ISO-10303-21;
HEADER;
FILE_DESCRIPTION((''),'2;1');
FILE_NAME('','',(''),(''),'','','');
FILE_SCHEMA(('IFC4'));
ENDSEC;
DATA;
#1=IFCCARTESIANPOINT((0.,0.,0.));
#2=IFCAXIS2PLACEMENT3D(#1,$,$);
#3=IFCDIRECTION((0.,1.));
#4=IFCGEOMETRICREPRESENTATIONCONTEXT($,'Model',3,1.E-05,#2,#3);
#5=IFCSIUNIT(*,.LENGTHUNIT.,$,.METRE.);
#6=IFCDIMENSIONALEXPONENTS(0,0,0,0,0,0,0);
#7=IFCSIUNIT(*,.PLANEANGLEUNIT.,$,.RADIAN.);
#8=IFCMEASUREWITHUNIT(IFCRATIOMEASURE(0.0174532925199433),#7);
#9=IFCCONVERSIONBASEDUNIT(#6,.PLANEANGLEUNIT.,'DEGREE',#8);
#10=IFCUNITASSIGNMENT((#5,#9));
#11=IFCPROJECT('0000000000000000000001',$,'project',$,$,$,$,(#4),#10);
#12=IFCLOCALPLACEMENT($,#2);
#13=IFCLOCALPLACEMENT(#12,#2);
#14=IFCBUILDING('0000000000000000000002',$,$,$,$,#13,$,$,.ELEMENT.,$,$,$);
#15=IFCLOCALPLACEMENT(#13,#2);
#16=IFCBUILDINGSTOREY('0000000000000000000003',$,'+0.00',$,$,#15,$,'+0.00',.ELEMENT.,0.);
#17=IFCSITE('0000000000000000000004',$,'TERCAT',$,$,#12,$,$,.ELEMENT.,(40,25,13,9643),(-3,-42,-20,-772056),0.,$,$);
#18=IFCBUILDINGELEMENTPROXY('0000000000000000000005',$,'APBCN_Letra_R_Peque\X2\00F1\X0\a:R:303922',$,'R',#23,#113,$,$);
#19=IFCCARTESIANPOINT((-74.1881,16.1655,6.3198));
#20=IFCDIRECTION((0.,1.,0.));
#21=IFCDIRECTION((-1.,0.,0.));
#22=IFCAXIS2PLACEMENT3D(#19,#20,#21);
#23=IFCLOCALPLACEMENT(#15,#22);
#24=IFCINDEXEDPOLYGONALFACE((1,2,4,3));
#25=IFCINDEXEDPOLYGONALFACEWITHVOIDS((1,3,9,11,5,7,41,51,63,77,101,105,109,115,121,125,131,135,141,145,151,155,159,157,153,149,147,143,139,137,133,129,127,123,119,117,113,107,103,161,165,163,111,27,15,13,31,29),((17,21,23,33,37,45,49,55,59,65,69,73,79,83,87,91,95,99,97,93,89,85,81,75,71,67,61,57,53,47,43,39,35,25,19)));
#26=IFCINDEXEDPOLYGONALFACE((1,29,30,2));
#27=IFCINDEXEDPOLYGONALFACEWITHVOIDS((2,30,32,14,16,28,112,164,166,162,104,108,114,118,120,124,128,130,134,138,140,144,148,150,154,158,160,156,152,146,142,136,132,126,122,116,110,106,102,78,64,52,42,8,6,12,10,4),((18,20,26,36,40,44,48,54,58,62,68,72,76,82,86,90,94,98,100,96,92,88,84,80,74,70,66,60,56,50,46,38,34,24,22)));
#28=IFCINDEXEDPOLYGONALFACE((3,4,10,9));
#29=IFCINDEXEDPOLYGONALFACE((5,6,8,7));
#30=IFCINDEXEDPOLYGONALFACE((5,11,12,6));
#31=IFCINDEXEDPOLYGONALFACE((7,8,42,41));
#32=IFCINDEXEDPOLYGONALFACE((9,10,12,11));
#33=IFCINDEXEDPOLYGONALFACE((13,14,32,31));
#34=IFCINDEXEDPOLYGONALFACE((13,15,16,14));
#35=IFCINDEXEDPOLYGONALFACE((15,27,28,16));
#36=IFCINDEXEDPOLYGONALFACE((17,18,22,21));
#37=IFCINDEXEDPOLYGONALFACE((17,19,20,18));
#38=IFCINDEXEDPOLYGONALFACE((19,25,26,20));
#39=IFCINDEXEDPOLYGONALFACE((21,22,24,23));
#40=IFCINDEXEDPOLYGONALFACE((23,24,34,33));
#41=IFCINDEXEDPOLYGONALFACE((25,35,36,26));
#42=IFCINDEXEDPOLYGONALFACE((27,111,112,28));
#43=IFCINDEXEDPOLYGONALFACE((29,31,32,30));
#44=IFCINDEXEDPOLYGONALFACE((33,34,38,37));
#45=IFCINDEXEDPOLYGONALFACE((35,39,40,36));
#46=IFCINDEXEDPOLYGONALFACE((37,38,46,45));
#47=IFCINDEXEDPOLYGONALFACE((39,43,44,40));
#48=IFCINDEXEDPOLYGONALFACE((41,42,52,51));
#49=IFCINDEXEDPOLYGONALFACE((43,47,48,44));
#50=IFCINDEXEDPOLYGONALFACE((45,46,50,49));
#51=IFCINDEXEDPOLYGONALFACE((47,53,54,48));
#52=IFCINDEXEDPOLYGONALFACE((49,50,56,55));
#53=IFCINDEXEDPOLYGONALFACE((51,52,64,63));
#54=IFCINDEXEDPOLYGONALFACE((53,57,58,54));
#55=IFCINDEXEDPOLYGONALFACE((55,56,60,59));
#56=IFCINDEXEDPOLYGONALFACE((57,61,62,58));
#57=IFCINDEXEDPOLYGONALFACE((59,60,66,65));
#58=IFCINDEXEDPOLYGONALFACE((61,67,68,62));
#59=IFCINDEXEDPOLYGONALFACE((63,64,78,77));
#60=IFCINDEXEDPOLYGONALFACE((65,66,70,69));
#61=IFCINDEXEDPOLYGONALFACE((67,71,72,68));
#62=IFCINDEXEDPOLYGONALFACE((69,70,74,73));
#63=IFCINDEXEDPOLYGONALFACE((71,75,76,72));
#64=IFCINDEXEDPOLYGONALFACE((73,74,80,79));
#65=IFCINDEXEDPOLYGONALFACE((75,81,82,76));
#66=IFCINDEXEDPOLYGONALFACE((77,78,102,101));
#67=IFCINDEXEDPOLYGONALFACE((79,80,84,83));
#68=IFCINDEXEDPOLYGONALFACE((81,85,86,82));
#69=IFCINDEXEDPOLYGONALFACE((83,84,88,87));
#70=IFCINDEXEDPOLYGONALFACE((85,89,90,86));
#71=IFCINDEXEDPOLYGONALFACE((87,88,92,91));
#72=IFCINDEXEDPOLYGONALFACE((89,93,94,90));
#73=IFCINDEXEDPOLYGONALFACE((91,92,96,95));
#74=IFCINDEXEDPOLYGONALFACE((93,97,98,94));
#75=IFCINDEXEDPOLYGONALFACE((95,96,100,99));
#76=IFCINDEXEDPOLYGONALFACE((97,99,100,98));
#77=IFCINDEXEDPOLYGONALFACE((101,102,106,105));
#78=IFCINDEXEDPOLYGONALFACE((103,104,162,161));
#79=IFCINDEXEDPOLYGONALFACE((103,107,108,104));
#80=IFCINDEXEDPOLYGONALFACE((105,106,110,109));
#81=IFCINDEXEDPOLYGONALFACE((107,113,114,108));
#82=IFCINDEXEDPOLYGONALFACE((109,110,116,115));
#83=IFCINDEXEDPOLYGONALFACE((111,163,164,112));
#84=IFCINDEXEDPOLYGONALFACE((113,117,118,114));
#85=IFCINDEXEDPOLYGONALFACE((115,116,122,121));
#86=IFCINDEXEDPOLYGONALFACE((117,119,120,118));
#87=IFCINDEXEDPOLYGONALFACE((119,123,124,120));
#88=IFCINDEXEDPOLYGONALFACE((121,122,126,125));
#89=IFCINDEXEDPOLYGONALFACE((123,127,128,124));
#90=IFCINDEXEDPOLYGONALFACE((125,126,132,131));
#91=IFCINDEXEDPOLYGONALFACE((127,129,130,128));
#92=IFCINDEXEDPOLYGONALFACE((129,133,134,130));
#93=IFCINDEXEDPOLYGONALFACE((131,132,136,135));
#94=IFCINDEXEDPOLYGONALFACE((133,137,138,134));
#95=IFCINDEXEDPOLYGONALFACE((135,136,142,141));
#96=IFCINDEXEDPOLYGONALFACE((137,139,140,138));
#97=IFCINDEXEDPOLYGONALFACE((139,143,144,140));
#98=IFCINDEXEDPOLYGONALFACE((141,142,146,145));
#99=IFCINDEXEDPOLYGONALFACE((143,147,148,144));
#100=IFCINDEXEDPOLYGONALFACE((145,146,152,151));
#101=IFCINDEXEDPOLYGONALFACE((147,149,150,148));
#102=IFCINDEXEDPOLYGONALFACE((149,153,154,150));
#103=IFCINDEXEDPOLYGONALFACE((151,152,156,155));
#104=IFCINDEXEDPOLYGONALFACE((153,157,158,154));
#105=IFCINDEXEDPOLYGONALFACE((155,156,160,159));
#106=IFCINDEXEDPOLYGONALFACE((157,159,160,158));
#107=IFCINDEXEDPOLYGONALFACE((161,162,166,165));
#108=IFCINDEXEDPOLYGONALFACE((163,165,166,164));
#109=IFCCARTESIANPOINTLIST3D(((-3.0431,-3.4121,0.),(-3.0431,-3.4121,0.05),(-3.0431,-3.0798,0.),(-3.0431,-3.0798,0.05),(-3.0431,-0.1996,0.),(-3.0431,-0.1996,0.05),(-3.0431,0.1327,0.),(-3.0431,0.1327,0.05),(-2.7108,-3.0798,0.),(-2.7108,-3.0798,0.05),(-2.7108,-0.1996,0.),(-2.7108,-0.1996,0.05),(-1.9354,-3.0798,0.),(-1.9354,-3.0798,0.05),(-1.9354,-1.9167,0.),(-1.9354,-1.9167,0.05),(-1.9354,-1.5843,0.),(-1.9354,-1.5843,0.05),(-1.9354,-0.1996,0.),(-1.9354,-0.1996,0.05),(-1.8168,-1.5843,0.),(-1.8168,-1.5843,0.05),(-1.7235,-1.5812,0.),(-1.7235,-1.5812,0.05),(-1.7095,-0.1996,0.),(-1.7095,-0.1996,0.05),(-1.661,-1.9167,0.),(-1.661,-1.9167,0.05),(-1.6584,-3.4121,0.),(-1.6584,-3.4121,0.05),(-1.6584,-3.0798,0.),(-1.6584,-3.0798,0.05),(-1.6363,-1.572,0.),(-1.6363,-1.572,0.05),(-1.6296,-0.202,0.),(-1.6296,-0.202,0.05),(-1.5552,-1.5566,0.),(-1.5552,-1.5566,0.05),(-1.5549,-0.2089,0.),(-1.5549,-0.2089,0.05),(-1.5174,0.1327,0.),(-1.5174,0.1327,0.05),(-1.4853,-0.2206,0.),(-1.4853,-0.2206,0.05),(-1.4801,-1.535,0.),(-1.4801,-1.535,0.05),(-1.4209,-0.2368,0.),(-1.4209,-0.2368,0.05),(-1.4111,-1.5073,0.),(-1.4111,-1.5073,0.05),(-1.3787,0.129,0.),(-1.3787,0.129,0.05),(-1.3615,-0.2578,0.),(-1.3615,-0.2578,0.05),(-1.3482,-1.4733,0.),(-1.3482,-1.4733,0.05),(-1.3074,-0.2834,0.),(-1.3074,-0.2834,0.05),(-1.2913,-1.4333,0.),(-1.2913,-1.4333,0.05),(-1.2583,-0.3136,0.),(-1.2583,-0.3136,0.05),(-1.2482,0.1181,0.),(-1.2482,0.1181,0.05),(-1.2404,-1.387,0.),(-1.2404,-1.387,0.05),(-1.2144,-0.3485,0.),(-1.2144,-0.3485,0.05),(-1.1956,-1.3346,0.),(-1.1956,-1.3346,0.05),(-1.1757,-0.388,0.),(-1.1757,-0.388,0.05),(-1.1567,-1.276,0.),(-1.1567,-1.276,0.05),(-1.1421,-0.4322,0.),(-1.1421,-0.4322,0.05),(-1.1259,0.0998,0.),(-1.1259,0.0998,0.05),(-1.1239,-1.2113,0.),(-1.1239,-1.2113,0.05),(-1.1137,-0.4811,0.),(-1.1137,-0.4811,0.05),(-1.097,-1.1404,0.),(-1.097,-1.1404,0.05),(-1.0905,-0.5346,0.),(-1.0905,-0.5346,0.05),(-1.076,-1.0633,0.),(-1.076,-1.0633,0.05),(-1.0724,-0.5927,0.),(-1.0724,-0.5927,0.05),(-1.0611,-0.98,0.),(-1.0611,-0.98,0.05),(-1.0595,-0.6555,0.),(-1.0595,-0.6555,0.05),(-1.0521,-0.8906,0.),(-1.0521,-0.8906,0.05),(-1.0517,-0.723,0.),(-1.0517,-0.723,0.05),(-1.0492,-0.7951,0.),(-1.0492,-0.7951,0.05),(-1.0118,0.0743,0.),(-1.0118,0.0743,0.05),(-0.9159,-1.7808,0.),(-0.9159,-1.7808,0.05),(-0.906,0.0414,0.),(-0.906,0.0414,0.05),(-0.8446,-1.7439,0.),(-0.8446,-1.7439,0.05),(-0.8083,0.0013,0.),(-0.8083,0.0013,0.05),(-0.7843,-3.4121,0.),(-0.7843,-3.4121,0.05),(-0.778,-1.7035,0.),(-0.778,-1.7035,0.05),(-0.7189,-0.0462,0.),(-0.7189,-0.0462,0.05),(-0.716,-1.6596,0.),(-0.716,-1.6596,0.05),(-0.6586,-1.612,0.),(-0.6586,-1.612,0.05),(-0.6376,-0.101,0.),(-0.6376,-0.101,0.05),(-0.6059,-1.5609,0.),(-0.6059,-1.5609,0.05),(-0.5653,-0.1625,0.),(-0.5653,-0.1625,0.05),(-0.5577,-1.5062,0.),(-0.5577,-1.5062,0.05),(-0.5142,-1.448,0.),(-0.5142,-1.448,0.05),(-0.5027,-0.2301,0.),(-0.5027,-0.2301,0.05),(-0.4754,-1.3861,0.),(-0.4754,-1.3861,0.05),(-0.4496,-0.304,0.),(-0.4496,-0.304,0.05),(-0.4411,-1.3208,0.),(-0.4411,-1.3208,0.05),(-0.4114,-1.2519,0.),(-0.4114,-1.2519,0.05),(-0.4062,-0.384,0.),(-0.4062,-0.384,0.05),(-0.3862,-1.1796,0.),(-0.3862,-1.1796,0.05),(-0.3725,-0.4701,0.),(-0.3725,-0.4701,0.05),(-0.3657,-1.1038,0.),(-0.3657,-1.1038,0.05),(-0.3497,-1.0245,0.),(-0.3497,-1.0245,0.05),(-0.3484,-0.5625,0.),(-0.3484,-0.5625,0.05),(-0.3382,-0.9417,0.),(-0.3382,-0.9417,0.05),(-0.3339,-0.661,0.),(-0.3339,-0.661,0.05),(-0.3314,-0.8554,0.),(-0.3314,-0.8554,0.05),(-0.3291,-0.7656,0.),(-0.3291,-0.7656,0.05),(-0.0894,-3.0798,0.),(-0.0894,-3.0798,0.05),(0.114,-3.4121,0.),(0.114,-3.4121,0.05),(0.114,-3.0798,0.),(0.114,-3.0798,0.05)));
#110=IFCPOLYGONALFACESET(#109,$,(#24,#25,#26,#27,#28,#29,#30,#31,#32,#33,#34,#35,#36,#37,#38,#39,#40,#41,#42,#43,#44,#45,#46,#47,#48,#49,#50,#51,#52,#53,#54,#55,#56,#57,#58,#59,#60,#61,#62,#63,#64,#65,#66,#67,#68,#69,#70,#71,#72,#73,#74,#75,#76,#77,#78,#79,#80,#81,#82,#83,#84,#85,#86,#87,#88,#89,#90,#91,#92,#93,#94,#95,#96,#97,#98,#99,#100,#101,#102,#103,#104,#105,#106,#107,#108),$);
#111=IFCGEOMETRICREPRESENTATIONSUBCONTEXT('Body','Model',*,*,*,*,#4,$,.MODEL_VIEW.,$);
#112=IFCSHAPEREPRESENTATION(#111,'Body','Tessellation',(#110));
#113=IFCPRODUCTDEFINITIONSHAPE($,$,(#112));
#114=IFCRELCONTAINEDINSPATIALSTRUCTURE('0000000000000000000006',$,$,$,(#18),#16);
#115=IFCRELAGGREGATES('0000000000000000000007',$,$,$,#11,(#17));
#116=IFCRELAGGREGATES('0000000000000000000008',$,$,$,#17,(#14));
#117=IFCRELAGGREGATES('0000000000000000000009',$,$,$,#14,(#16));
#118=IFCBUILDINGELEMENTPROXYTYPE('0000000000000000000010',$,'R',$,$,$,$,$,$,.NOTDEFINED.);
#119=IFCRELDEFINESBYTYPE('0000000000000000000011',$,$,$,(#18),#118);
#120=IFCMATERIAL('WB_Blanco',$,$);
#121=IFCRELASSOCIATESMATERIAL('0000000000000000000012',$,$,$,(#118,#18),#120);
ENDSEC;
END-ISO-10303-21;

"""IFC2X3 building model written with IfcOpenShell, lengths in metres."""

from ifc_helpers import new_model, entity, si_unit, converted_unit, direction, frame, origin, place, context, subcontext, project, spatial, polyline, outline, extrude, source, transform, mapped, material, type_object, type_shapes, element, save


model = new_model("IFC2X3")

# Units and contexts
model_context = context("Model", 3, precision=1e-05, world=origin(), true_north=direction((0.0, 1.0)))
body_context = subcontext(model_context, "Body", "Model", "MODEL_VIEW")
ifc_project = project(units=[si_unit("LENGTHUNIT", "METRE"), converted_unit("PLANEANGLEUNIT", "DEGREE", entity("IfcRatioMeasure", 0.0174532925199433), si_unit("PLANEANGLEUNIT", "RADIAN"), dimensions=[0, 0, 0, 0, 0, 0, 0])], contexts=[model_context])

# Site, building, storey
site_placement = place(None, origin())
site = spatial("IfcSite", under=ifc_project, at=site_placement, Name="TERCAT", CompositionType="ELEMENT", RefLatitude=(40, 25, 13, 9643), RefLongitude=(-3, -42, -20, -772056), RefElevation=0.0)
building_placement = place(site_placement, origin())
building = spatial("IfcBuilding", under=site, at=building_placement, CompositionType="ELEMENT")
storey_placement = place(building_placement, origin())
storey = spatial("IfcBuildingStorey", under=building, at=storey_placement, Name="+0.00", LongName="+0.00", CompositionType="ELEMENT", Elevation=0.0)

# Building element proxy
ifc_material_1 = material(Name="WB_Blanco")
building_element_proxy_type_1 = type_object("IfcBuildingElementProxyType", Name="R", PredefinedType="NOTDEFINED", material=ifc_material_1)
shared_shape_1 = source(origin(), body_context, "Body", "SweptSolid", [
    extrude(outline(polyline([(-0.9262, 0.6376), (-0.9262, 1.8007), (-0.6493, 1.8007), (-0.6493, 2.133), (-2.034, 2.133), (-2.034, 1.8007), (-1.7016, 1.8007), (-1.7016, -1.0795), (-2.034, -1.0795), (-2.034, -1.4118), (-0.5082, -1.4118), (-0.3695, -1.4081), (-0.239, -1.3972), (-0.1168, -1.3789), (-0.0027, -1.3534), (0.1032, -1.3205), (0.2008, -1.2803), (0.2903, -1.2329), (0.3715, -1.1781), (0.4438, -1.1166), (0.5065, -1.049), (0.5595, -0.9751), (0.6029, -0.8951), (0.6366, -0.809), (0.6608, -0.7166), (0.6752, -0.6181), (0.68, -0.5135), (0.6777, -0.4237), (0.6709, -0.3374), (0.6595, -0.2546), (0.6435, -0.1753), (0.6229, -0.0995), (0.5978, -0.0271), (0.5681, 0.0417), (0.5338, 0.1071), (0.4949, 0.1689), (0.4514, 0.2271), (0.4033, 0.2818), (0.3505, 0.3329), (0.2931, 0.3805), (0.2311, 0.4245), (0.1645, 0.4649), (0.0933, 0.5017), (0.9198, 1.8007), (1.1231, 1.8007), (1.1231, 2.133), (0.2248, 2.133), (-0.6519, 0.6376), (-0.9262, 0.6376)]), holes=[polyline([(-0.9262, 0.3052), (-0.8076, 0.3052), (-0.7144, 0.3022), (-0.6272, 0.2929), (-0.5461, 0.2775), (-0.471, 0.2559), (-0.402, 0.2282), (-0.339, 0.1942), (-0.2821, 0.1542), (-0.2313, 0.1079), (-0.1864, 0.0555), (-0.1476, -0.0031), (-0.1147, -0.0678), (-0.0878, -0.1387), (-0.0669, -0.2158), (-0.052, -0.2991), (-0.043, -0.3885), (-0.04, -0.484), (-0.0426, -0.5561), (-0.0503, -0.6236), (-0.0633, -0.6864), (-0.0813, -0.7445), (-0.1046, -0.798), (-0.133, -0.8469), (-0.1666, -0.8911), (-0.2053, -0.9306), (-0.2492, -0.9655), (-0.2982, -0.9957), (-0.3524, -1.0213), (-0.4117, -1.0422), (-0.4762, -1.0585), (-0.5457, -1.0702), (-0.6205, -1.0771), (-0.7003, -1.0795), (-0.9262, -1.0795), (-0.9262, 0.3052)])]), frame((-1.0091, -1.2791, 0.0), z_axis=(0.0, 0.0, -1.0), x_axis=(1.0, 0.0, 0.0)), (0.0, 0.0, -1.0), 0.05),
])
type_shapes(building_element_proxy_type_1, [shared_shape_1])
proxy_1_placement = place(storey_placement, frame((-74.1881, 16.1655, 6.3198), z_axis=(0.0, 1.0, 0.0), x_axis=(-1.0, 0.0, 0.0)))
element("IfcBuildingElementProxy", 1, at=proxy_1_placement, inside=storey, type_object=building_element_proxy_type_1, material=ifc_material_1, Name="APBCN_Letra_R_Pequeña:R:303922", ObjectType="R", context=body_context, shape_type="MappedRepresentation", body=[
    mapped(shared_shape_1, transform((0.0, 0.0, 0.0), scale=1.0)),
])

save(model, "model.ifc")
